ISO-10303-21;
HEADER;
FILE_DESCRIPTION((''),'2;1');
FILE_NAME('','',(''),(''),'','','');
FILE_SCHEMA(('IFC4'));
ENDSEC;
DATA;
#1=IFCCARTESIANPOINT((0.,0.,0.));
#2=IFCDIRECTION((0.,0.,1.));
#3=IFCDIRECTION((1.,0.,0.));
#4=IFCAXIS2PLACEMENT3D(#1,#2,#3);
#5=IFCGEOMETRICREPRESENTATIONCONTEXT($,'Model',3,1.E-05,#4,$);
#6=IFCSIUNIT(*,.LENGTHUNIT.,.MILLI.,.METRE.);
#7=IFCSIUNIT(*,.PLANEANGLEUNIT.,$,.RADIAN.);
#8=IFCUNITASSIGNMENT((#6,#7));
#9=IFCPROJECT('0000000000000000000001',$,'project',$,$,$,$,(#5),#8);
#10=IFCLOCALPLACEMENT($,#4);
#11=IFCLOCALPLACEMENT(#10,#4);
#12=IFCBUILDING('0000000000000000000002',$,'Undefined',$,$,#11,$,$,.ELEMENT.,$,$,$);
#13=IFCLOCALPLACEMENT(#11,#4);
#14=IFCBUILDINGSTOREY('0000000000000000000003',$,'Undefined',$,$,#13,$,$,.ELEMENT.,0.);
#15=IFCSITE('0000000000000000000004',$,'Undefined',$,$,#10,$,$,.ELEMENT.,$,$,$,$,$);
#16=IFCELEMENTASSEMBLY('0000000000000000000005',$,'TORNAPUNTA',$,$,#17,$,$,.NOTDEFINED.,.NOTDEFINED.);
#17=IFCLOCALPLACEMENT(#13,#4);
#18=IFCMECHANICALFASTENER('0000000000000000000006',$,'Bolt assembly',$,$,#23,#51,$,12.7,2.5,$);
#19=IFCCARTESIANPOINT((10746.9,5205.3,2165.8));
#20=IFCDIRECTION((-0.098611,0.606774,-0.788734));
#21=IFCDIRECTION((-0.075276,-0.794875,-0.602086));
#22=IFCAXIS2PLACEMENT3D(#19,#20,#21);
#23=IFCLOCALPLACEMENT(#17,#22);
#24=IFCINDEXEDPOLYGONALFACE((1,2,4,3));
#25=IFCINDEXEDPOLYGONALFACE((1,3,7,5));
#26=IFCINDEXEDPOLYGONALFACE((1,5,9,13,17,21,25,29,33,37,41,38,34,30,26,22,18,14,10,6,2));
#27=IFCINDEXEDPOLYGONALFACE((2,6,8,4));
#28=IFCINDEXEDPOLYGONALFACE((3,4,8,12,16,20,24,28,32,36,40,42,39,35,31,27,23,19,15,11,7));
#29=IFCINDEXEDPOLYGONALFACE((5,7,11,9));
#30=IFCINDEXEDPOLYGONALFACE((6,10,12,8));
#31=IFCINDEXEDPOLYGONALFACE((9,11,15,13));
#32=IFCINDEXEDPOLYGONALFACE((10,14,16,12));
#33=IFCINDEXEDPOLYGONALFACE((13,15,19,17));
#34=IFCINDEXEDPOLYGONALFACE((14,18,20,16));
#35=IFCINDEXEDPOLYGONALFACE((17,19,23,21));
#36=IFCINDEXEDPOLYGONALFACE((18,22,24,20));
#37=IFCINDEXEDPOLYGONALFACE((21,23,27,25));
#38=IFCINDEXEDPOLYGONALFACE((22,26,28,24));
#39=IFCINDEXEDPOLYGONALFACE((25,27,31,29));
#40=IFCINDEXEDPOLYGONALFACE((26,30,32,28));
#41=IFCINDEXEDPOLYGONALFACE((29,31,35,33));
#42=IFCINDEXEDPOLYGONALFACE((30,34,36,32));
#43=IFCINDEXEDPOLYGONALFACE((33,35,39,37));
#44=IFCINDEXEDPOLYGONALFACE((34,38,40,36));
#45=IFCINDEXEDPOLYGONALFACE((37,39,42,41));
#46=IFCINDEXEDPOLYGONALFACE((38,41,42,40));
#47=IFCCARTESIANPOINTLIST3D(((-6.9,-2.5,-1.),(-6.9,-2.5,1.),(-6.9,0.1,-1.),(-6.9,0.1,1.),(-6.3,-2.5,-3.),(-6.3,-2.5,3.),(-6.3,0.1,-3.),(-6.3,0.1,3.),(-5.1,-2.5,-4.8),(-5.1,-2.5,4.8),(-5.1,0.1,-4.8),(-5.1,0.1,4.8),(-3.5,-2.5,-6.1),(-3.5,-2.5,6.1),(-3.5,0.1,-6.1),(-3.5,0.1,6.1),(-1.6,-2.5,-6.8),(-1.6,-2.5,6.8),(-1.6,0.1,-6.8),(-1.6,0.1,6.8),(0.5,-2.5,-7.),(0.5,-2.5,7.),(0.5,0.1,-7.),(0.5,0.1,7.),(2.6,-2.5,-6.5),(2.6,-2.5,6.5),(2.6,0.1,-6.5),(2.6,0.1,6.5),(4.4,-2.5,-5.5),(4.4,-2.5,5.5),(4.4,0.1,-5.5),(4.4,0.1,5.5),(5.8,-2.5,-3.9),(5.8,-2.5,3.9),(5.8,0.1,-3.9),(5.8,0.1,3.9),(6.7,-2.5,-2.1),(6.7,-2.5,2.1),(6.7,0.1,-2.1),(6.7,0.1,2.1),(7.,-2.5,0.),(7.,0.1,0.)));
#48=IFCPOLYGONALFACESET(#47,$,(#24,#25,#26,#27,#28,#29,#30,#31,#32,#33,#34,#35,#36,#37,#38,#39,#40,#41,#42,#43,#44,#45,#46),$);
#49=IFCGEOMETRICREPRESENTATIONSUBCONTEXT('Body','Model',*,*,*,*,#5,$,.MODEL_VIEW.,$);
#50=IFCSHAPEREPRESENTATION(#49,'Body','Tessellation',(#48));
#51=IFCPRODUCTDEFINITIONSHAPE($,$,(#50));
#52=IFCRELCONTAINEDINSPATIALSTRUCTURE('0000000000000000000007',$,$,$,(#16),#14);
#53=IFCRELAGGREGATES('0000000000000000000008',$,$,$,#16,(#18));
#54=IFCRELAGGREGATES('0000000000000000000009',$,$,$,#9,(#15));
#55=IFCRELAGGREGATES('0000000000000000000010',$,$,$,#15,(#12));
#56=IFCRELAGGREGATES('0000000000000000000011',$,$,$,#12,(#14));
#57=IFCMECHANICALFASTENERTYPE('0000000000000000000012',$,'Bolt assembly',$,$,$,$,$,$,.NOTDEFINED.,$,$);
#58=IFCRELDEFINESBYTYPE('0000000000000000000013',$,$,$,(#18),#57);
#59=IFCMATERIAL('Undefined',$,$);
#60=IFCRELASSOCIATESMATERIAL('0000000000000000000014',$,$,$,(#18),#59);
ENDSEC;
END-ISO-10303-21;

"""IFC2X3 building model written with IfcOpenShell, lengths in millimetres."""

from ifc_helpers import new_model, si_unit, frame, origin_with_axes, origin_2d_with_axis, place, context, subcontext, project, spatial, circle, extrude, source, transform, mapped, material, type_object, element, aggregate, save


model = new_model("IFC2X3")

# Units and contexts
model_context = context("Model", 3, precision=1e-05, world=origin_with_axes())
body_context = subcontext(model_context, "Body", "Model", "MODEL_VIEW")
ifc_project = project(units=[si_unit("LENGTHUNIT", "METRE", prefix="MILLI"), si_unit("PLANEANGLEUNIT", "RADIAN")], contexts=[model_context])

# Site, building, storey
site_placement = place(None, origin_with_axes())
site = spatial("IfcSite", under=ifc_project, at=site_placement, Name="Undefined", CompositionType="ELEMENT")
building_placement = place(site_placement, origin_with_axes())
building = spatial("IfcBuilding", under=site, at=building_placement, Name="Undefined", CompositionType="ELEMENT")
storey_placement = place(building_placement, origin_with_axes())
storey = spatial("IfcBuildingStorey", under=building, at=storey_placement, Name="Undefined", CompositionType="ELEMENT", Elevation=0.0)

# Shared definitions
ifc_material_1 = material(Name="Undefined")
mechanical_fastener_type = type_object("IfcMechanicalFastenerType", Name="Bolt assembly")

# Element assembly, mechanical fastener
assembly_1_placement = place(storey_placement, origin_with_axes())
assembly_1 = element("IfcElementAssembly", 1, at=assembly_1_placement, inside=storey, Name="TORNAPUNTA", AssemblyPlace="NOTDEFINED", PredefinedType="NOTDEFINED")
shared_shape_1 = source(origin_with_axes(), body_context, "Body", "SweptSolid", [
    extrude(circle(Radius=7.0, at=origin_2d_with_axis()), frame((0.0, -2.5, 0.0), z_axis=(0.0, 1.0, 0.0), x_axis=(1.0, 0.0, 0.0)), (0.0, 0.0, 1.0), 2.6),
])
mechanical_fastener_1_placement = place(assembly_1_placement, frame((10746.9, 5205.3, 2165.8), z_axis=(-0.098611, 0.606774, -0.788734), x_axis=(-0.075276, -0.794875, -0.602086)))
mechanical_fastener_1 = element("IfcMechanicalFastener", 2, at=mechanical_fastener_1_placement, type_object=mechanical_fastener_type, material=ifc_material_1, Name="Bolt assembly", NominalDiameter=12.7, NominalLength=2.5, context=body_context, shape_type="MappedRepresentation", body=[
    mapped(shared_shape_1, transform((0.0, 0.0, 0.0))),
])
aggregate(assembly_1, [mechanical_fastener_1])

save(model, "model.ifc")
